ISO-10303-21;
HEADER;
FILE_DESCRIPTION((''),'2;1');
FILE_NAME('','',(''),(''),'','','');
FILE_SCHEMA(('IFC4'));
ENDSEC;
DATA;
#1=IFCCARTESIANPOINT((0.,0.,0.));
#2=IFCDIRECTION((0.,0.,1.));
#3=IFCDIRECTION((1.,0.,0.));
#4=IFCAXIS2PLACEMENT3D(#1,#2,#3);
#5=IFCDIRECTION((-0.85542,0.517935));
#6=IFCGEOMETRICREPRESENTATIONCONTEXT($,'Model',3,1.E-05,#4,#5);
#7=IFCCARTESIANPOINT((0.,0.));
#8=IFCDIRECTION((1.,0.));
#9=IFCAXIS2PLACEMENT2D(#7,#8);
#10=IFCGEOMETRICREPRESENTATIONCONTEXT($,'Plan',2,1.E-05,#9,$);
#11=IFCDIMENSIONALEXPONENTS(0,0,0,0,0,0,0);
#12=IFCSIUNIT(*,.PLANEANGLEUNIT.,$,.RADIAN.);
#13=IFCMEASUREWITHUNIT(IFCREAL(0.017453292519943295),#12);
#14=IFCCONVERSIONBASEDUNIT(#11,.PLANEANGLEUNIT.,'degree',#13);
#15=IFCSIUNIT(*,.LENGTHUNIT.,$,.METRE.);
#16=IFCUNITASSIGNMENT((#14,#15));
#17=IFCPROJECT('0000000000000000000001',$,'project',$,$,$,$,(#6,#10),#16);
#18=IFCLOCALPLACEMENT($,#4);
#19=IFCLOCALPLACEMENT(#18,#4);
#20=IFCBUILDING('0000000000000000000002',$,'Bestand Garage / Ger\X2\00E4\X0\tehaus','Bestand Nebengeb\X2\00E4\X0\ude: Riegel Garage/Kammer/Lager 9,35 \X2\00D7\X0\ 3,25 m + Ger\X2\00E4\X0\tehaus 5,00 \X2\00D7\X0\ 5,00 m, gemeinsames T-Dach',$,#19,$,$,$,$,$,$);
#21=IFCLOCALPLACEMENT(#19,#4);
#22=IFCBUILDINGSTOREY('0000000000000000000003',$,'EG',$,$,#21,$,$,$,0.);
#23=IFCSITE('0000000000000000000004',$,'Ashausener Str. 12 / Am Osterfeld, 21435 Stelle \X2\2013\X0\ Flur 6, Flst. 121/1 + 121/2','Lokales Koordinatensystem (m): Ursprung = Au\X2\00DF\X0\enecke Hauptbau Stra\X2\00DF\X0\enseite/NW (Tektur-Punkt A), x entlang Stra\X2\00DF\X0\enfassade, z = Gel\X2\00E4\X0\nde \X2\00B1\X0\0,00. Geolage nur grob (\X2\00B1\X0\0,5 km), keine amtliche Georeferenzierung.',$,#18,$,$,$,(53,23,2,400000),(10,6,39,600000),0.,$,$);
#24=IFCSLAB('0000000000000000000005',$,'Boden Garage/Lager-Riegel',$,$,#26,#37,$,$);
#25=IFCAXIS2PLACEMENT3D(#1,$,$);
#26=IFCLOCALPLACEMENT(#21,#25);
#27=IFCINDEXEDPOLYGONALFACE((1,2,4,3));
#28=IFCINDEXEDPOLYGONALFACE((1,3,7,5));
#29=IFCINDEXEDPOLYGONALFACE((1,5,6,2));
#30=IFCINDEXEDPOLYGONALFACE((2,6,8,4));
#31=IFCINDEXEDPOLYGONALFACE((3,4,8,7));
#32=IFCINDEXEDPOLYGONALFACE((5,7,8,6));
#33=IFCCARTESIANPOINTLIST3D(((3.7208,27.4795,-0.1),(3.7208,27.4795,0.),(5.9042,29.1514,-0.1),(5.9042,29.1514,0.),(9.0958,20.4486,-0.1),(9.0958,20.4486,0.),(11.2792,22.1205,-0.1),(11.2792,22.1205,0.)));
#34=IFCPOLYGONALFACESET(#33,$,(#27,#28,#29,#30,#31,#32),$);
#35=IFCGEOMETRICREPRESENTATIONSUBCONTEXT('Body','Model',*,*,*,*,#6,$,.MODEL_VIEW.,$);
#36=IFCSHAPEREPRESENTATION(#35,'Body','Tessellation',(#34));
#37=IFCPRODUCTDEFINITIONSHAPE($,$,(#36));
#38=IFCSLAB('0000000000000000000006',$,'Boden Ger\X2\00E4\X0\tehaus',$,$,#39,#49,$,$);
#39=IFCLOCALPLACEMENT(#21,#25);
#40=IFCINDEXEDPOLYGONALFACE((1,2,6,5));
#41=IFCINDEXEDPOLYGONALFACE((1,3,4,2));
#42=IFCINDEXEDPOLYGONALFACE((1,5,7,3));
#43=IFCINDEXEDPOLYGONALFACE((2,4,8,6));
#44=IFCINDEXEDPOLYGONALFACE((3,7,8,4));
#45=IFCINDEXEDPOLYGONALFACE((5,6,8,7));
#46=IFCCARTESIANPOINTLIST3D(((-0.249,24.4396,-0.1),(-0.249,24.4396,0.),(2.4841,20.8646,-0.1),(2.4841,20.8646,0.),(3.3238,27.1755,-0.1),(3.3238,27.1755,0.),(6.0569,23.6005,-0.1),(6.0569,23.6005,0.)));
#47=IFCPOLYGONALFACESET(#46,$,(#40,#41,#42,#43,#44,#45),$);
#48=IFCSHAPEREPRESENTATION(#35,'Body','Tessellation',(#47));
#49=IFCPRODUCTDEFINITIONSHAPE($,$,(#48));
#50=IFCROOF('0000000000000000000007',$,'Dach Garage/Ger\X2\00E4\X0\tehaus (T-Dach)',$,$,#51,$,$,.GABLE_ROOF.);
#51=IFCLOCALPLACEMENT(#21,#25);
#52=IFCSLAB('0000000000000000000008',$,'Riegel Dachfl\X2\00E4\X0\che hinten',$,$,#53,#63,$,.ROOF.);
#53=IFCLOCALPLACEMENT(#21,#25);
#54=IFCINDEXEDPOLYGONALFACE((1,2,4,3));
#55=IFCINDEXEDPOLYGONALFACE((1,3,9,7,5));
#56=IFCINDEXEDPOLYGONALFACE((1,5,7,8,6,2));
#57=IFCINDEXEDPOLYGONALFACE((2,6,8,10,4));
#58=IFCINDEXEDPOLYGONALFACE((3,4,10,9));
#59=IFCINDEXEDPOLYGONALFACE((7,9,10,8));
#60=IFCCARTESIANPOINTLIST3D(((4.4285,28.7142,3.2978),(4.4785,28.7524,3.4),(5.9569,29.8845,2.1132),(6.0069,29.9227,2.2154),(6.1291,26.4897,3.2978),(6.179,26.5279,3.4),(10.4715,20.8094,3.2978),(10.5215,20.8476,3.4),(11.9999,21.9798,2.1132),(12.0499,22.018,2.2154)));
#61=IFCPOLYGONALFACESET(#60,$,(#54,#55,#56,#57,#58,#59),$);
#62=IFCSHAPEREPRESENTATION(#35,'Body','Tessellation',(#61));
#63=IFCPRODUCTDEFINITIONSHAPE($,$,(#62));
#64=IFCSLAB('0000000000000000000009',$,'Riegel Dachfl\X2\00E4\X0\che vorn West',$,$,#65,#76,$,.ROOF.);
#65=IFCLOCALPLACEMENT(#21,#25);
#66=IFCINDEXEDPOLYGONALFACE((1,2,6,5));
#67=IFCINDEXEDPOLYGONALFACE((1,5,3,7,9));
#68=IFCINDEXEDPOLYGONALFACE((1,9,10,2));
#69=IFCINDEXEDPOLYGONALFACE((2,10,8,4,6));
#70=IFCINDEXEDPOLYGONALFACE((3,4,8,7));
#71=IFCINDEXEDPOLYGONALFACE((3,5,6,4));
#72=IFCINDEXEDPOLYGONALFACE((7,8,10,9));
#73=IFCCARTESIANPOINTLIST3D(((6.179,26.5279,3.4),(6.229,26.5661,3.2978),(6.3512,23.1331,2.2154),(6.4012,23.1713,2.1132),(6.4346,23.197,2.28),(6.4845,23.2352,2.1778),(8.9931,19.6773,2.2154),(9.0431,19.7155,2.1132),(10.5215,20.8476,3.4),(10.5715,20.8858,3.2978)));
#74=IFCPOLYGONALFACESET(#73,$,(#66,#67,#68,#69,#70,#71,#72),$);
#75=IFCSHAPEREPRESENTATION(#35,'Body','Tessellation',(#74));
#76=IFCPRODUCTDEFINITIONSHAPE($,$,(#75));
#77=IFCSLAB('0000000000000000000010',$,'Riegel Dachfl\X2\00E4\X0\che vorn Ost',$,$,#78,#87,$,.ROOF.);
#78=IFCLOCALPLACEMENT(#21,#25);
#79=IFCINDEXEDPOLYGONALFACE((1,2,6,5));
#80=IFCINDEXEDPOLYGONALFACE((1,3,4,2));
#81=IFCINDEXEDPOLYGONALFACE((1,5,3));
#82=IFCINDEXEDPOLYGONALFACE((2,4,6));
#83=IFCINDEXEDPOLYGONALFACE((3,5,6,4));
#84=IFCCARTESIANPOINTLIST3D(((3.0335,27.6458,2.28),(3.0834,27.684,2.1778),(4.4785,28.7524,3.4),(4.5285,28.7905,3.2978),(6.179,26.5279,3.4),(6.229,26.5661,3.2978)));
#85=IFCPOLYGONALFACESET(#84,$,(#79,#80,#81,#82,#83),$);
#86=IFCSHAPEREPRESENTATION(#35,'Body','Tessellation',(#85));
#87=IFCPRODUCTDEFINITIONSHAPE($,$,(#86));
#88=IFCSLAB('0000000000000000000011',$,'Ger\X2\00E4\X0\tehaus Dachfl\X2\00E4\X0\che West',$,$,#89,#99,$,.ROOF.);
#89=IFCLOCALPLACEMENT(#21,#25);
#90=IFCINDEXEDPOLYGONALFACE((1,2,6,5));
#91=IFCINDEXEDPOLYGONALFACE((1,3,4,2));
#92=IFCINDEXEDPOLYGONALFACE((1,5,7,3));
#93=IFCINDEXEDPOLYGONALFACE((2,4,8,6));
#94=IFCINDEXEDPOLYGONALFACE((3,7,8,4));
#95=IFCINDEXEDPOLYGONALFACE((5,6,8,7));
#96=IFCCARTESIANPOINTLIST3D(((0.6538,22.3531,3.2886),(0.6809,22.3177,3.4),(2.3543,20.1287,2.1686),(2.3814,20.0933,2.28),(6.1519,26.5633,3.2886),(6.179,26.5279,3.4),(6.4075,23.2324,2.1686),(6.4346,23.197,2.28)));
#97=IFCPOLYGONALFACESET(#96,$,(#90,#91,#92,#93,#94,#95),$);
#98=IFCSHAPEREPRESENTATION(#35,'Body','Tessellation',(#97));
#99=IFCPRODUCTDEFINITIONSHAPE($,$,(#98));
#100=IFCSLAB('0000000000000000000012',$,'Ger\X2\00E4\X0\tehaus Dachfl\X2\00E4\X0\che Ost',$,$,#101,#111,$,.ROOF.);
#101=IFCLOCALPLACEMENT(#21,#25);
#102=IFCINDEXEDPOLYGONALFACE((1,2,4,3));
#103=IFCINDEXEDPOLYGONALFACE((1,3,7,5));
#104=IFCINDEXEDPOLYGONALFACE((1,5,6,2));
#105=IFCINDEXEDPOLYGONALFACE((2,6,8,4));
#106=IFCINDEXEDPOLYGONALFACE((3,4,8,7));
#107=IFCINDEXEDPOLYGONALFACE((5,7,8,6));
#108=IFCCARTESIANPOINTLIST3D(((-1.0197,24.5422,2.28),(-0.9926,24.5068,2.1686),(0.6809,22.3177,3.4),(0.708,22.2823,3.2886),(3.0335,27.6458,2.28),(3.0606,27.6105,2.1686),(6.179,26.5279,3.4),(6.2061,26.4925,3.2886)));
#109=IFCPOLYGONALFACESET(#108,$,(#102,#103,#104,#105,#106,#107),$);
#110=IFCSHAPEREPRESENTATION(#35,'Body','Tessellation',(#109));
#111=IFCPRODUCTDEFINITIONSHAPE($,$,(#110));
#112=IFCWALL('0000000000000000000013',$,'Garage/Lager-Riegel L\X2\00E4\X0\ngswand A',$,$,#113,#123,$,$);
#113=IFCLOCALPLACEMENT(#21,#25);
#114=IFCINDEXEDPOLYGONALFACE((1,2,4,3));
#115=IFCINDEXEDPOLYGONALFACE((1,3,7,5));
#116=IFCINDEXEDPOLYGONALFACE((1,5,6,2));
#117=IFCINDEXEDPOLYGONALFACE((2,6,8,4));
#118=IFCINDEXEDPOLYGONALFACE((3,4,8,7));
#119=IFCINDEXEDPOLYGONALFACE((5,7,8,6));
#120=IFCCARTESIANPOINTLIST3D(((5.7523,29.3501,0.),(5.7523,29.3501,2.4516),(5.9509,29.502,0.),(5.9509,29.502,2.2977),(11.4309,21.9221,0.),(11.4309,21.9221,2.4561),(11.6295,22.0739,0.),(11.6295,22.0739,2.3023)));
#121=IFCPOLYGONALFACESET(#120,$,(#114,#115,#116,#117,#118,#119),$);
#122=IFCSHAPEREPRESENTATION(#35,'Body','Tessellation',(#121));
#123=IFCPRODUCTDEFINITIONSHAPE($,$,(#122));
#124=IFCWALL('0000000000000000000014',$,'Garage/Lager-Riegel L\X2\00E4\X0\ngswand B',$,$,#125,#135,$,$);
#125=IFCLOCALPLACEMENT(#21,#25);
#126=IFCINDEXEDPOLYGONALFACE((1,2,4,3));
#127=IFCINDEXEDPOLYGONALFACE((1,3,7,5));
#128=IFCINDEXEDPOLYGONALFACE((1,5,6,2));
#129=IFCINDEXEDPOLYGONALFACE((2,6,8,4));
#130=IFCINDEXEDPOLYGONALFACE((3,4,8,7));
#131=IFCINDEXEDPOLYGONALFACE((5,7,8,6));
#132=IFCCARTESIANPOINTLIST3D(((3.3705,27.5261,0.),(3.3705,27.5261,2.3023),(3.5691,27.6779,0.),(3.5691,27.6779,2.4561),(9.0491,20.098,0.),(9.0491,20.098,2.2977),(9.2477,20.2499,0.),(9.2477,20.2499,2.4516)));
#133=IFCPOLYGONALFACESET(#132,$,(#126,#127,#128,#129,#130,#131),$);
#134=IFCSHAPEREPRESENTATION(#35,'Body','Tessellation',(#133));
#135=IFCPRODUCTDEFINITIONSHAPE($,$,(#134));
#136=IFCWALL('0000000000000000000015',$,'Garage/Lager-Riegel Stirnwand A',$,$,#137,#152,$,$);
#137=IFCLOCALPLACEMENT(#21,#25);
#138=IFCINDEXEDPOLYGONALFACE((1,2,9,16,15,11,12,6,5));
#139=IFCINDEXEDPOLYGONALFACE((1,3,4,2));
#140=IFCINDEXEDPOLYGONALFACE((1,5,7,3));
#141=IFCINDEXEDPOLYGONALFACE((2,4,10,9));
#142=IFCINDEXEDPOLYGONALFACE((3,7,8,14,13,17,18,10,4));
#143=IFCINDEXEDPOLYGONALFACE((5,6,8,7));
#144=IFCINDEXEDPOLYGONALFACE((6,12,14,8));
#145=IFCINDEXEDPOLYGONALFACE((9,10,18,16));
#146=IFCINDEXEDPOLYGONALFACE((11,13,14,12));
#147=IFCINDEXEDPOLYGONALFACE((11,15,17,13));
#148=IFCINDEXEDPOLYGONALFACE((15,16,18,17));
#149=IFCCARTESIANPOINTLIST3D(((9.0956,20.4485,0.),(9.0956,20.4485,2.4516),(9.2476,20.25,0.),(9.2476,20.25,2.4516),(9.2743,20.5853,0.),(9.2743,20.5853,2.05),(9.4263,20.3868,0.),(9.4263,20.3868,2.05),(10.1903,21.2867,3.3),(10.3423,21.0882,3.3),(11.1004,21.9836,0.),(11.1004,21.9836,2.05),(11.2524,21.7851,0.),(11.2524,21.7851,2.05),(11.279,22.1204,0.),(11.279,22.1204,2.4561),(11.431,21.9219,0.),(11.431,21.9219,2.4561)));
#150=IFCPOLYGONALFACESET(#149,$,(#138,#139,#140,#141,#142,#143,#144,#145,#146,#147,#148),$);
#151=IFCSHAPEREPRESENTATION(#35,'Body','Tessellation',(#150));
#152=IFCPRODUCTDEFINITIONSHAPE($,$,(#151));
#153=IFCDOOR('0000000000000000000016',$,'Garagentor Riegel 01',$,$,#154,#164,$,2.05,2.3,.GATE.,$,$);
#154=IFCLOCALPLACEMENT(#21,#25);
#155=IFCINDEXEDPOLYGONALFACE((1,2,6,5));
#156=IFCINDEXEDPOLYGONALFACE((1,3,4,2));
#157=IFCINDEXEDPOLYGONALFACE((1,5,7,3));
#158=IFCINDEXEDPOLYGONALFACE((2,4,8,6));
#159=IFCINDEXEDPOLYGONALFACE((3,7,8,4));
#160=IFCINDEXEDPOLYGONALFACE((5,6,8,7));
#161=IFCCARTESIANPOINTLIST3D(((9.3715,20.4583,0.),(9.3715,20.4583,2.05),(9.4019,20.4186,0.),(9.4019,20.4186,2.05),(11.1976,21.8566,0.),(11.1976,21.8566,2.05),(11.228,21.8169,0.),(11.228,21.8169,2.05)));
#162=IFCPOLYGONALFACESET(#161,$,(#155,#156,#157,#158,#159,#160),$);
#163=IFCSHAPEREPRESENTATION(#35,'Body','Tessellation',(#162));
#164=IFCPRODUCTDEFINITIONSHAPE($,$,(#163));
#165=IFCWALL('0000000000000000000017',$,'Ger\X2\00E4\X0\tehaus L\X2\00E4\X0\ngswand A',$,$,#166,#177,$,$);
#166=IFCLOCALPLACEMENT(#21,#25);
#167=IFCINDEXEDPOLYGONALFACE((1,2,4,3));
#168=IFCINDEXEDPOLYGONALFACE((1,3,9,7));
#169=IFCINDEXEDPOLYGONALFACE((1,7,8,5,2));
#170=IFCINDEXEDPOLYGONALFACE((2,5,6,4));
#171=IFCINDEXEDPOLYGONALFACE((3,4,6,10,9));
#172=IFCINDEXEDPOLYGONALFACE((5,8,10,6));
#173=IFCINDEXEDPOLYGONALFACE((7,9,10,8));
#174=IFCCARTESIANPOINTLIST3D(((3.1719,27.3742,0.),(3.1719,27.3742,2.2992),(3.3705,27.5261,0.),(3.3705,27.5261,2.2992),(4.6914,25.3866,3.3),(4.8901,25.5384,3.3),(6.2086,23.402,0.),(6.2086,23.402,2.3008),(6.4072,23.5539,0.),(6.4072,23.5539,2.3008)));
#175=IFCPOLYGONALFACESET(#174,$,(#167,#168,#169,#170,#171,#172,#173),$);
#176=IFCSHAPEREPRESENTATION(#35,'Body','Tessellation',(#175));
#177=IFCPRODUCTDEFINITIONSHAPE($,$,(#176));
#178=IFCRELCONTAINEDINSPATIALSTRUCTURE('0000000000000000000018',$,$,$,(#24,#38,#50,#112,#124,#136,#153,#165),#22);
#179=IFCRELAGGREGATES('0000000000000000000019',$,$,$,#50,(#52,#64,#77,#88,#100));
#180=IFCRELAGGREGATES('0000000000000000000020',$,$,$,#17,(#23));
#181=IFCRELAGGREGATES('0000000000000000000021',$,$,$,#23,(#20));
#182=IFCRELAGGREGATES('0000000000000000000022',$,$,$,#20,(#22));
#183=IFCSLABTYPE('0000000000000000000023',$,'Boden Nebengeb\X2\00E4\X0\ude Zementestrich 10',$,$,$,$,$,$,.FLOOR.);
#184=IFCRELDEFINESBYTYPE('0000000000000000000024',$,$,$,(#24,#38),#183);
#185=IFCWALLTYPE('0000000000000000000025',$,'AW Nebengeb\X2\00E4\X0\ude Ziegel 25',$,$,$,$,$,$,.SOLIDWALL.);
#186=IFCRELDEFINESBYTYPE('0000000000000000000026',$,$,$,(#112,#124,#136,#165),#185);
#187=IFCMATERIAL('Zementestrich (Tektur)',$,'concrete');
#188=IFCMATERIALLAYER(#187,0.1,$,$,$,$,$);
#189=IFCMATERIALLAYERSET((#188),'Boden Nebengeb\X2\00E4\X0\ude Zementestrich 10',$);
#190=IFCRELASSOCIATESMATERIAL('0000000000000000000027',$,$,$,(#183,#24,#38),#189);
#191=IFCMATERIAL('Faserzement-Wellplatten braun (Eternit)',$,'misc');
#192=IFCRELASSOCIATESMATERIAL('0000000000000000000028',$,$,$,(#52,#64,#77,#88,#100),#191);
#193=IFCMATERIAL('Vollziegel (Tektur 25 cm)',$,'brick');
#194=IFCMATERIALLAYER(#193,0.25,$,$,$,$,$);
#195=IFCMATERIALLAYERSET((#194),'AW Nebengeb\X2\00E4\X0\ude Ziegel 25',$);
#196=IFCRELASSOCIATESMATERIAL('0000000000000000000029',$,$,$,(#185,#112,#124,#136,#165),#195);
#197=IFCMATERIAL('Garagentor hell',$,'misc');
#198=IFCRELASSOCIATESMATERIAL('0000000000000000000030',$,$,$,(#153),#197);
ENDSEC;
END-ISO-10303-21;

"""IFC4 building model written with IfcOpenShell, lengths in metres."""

from ifc_helpers import new_model, entity, si_unit, converted_unit, direction, frame, origin_with_axes, origin_2d_with_axis, place, context, subcontext, project, spatial, polyline, indexed_curve, outline, extrude, clip, halfspace, material, layer, layer_set, layer_usage, type_object, element, fill, aggregate, save


model = new_model("IFC4")

# Units and contexts
model_context = context("Model", 3, precision=1e-05, world=origin_with_axes(), true_north=direction((-0.85542, 0.517935)))
plan_context = context("Plan", 2, precision=1e-05, world=origin_2d_with_axis())
body_context = subcontext(model_context, "Body", "Model", "MODEL_VIEW")
ifc_project = project(units=[converted_unit("PLANEANGLEUNIT", "degree", entity("IfcReal", 0.017453292519943295), si_unit("PLANEANGLEUNIT", "RADIAN"), dimensions=[0, 0, 0, 0, 0, 0, 0]), si_unit("LENGTHUNIT", "METRE")], contexts=[model_context, plan_context])

# Site, building, storey
site_placement = place(None, origin_with_axes())
site = spatial("IfcSite", under=ifc_project, at=site_placement, Name="Ashausener Str. 12 / Am Osterfeld, 21435 Stelle – Flur 6, Flst. 121/1 + 121/2", Description="Lokales Koordinatensystem (m): Ursprung = Außenecke Hauptbau Straßenseite/NW (Tektur-Punkt A), x entlang Straßenfassade, z = Gelände ±0,00. Geolage nur grob (±0,5 km), keine amtliche Georeferenzierung.", RefLatitude=(53, 23, 2, 400000), RefLongitude=(10, 6, 39, 600000), RefElevation=0.0)
building_placement = place(site_placement, origin_with_axes())
building = spatial("IfcBuilding", under=site, at=building_placement, Name="Bestand Garage / Gerätehaus", Description="Bestand Nebengebäude: Riegel Garage/Kammer/Lager 9,35 × 3,25 m + Gerätehaus 5,00 × 5,00 m, gemeinsames T-Dach")
storey_placement = place(building_placement, origin_with_axes())
storey = spatial("IfcBuildingStorey", under=building, at=storey_placement, Name="EG", Elevation=0.0)

# Slabs
ifc_material_1 = material(Name="Zementestrich (Tektur)", Category="concrete")
ifc_layer_1 = layer(ifc_material_1, 0.1)
ifc_layer_set_1 = layer_set([ifc_layer_1], Name="Boden Nebengebäude Zementestrich 10")
ifc_layer_usage_1 = layer_usage(ifc_layer_set_1, "AXIS3", "POSITIVE", 0.0)
slab_type = type_object("IfcSlabType", Name="Boden Nebengebäude Zementestrich 10", PredefinedType="FLOOR", material=ifc_layer_set_1)
slab_1_placement = place(storey_placement, origin_with_axes())
element("IfcSlab", 1, at=slab_1_placement, inside=storey, type_object=slab_type, material=ifc_layer_usage_1, Name="Boden Garage/Lager-Riegel", context=body_context, shape_type="SweptSolid", body=[
    extrude(outline(polyline([(11.2792, 22.1205), (5.9042, 29.1514), (3.7208, 27.4795), (9.0958, 20.4486), (11.2792, 22.1205)])), frame((0.0, 0.0, -0.1)), (0.0, 0.0, 1.0), 0.1),
])
ifc_layer_usage_2 = layer_usage(ifc_layer_set_1, "AXIS3", "POSITIVE", 0.0)
slab_2_placement = place(storey_placement, origin_with_axes())
element("IfcSlab", 2, at=slab_2_placement, inside=storey, type_object=slab_type, material=ifc_layer_usage_2, Name="Boden Gerätehaus", context=body_context, shape_type="SweptSolid", body=[
    extrude(outline(polyline([(6.0569, 23.6005), (3.3238, 27.1755), (-0.249, 24.4396), (2.4841, 20.8646), (6.0569, 23.6005)])), frame((0.0, 0.0, -0.1)), (0.0, 0.0, 1.0), 0.1),
])

# Roof, slabs
roof_placement = place(storey_placement, origin_with_axes())
roof = element("IfcRoof", 3, at=roof_placement, inside=storey, Name="Dach Garage/Gerätehaus (T-Dach)", PredefinedType="GABLE_ROOF")
ifc_material_2 = material(Name="Faserzement-Wellplatten braun (Eternit)", Category="misc")
slab_3_placement = place(roof_placement, origin_with_axes())
slab_3 = element("IfcSlab", 4, at=slab_3_placement, material=ifc_material_2, Name="Riegel Dachfläche hinten", PredefinedType="ROOF", context=body_context, shape_type="SweptSolid", body=[
    extrude(outline(polyline([(0.0, 0.0), (9.95, 0.0), (9.9485, 2.2603), (7.1485, 2.2603), (-0.0015, 2.2603), (0.0, 0.0)])), frame((12.0499, 22.018, 2.2154), z_axis=(0.416367, 0.318306, 0.851657), x_axis=(-0.607339, 0.794443, 0.0)), (0.0, 0.0, -1.0), 0.12),
])
slab_4_placement = place(roof_placement, origin_with_axes())
slab_4 = element("IfcSlab", 5, at=slab_4_placement, material=ifc_material_2, Name="Riegel Dachfläche vorn West", PredefinedType="ROOF", context=body_context, shape_type="SweptSolid", body=[
    extrude(outline(polyline([(0.0, 0.0), (7.15, 0.0), (4.3486, 2.137), (4.3485, 2.2603), (-0.0015, 2.2603), (0.0, 0.0)])), frame((10.5215, 20.8476, 3.4), z_axis=(-0.416366, -0.318306, 0.851658), x_axis=(-0.607339, 0.794443, 0.0)), (0.0, 0.0, -1.0), 0.12),
])
slab_5_placement = place(roof_placement, origin_with_axes())
slab_5 = element("IfcSlab", 6, at=slab_5_placement, material=ifc_material_2, Name="Riegel Dachfläche vorn Ost", PredefinedType="ROOF", context=body_context, shape_type="SweptSolid", body=[
    extrude(outline(polyline([(0.0, 0.0), (2.8, 0.0), (2.7986, 2.137), (0.0, 0.0)])), frame((6.179, 26.5279, 3.4), z_axis=(-0.416366, -0.318305, 0.851658), x_axis=(-0.607339, 0.794443, 0.0)), (0.0, 0.0, -1.0), 0.12),
])
slab_6_placement = place(roof_placement, origin_with_axes())
slab_6 = element("IfcSlab", 7, at=slab_6_placement, material=ifc_material_2, Name="Gerätehaus Dachfläche West", PredefinedType="ROOF", context=body_context, shape_type="SweptSolid", body=[
    extrude(outline(polyline([(0.0, 0.0), (6.925, 0.0), (6.9272, 3.0157), (1.8222, 3.0157), (0.0, 0.0)])), frame((6.179, 26.5279, 3.4), z_axis=(0.225794, -0.294869, 0.928477), x_axis=(-0.79396, -0.60797, 0.0)), (0.0, 0.0, -1.0), 0.12),
])
slab_7_placement = place(roof_placement, origin_with_axes())
slab_7 = element("IfcSlab", 8, at=slab_7_placement, material=ifc_material_2, Name="Gerätehaus Dachfläche Ost", PredefinedType="ROOF", context=body_context, shape_type="SweptSolid", body=[
    extrude(outline(polyline([(0.0, 0.0), (3.5212, 0.0), (6.1566, 4.3721), (3.575, 5.9309), (0.0, 0.0)])), frame((6.179, 26.5279, 3.4), z_axis=(-0.225794, 0.294869, 0.928477), x_axis=(-0.893325, 0.317489, -0.318075)), (0.0, 0.0, -1.0), 0.12),
])
aggregate(roof, [slab_3, slab_4, slab_5, slab_6, slab_7])

# Walls
ifc_material_3 = material(Name="Vollziegel (Tektur 25 cm)", Category="brick")
ifc_layer_2 = layer(ifc_material_3, 0.25)
ifc_layer_set_2 = layer_set([ifc_layer_2], Name="AW Nebengebäude Ziegel 25")
ifc_layer_usage_3 = layer_usage(ifc_layer_set_2, "AXIS2", "POSITIVE", 0.0)
wall_type = type_object("IfcWallType", Name="AW Nebengebäude Ziegel 25", PredefinedType="SOLIDWALL", material=ifc_layer_set_2)
wall_1_placement = place(storey_placement, frame((11.6295, 22.0739, 0.0), z_axis=(0.0, 0.0, 1.0), x_axis=(-0.607339, 0.794443, 0.0)))
element("IfcWall", 9, at=wall_1_placement, inside=storey, type_object=wall_type, material=ifc_layer_usage_3, Name="Garage/Lager-Riegel Längswand A", context=body_context, shape_type="Clipping", body=[
    clip(clip(extrude(outline(indexed_curve([(0.0, 0.0), (0.0, 0.25), (9.35, 0.25), (9.35, 0.0), (0.0, 0.0)], self_intersect=False)), origin_with_axes(), (0.0, 0.0, 1.0), 6.0), halfspace(frame((4.6724, 3.25, 2.3), z_axis=(-0.000416, 0.5241, 0.85166), x_axis=(1.0, 0.000795, 0.0)), False)), halfspace(frame((4.675, 0.0, 2.3), z_axis=(0.000416, -0.5241, 0.85166), x_axis=(-1.0, -0.000795, 0.0)), False)),
])
ifc_layer_usage_4 = layer_usage(ifc_layer_set_2, "AXIS2", "POSITIVE", 0.0)
wall_2_placement = place(storey_placement, frame((3.3705, 27.5261, 0.0), z_axis=(0.0, 0.0, 1.0), x_axis=(0.607339, -0.794443, 0.0)))
element("IfcWall", 10, at=wall_2_placement, inside=storey, type_object=wall_type, material=ifc_layer_usage_4, Name="Garage/Lager-Riegel Längswand B", context=body_context, shape_type="Clipping", body=[
    clip(clip(extrude(outline(indexed_curve([(0.0, 0.0), (0.0, 0.25), (9.35, 0.25), (9.35, 0.0), (0.0, 0.0)], self_intersect=False)), origin_with_axes(), (0.0, 0.0, 1.0), 6.0), halfspace(frame((4.675, 0.0, 2.3), z_axis=(0.000416, -0.5241, 0.85166), x_axis=(-1.0, -0.000795, 0.0)), False)), halfspace(frame((4.6724, 3.25, 2.3), z_axis=(-0.000416, 0.5241, 0.85166), x_axis=(1.0, 0.000795, 0.0)), False)),
])

# Wall, opening, door
ifc_layer_usage_5 = layer_usage(ifc_layer_set_2, "AXIS2", "POSITIVE", 0.0)
wall_3_placement = place(storey_placement, frame((9.2476, 20.25, 0.0), z_axis=(0.0, 0.0, 1.0), x_axis=(0.79396, 0.60797, 0.0)))
wall_3 = element("IfcWall", 11, at=wall_3_placement, inside=storey, type_object=wall_type, material=ifc_layer_usage_5, Name="Garage/Lager-Riegel Stirnwand A", context=body_context, shape_type="Clipping", body=[
    clip(clip(extrude(outline(indexed_curve([(0.0, 0.0), (0.0, 0.25), (2.75, 0.25), (2.75, 0.0), (0.0, 0.0)], self_intersect=False)), origin_with_axes(), (0.0, 0.0, 1.0), 6.0), halfspace(frame((-0.2463, 4.675, 2.3), z_axis=(-0.5241, 0.0, 0.85166), x_axis=(0.0, 1.0, 0.0)), False)), halfspace(frame((3.0037, 4.675, 2.3), z_axis=(0.5241, 0.0, 0.85166), x_axis=(0.0, -1.0, 0.0)), False)),
])
opening_1_placement = place(wall_3_placement, frame((0.225, -0.1, 0.0), z_axis=(0.0, 0.0, 1.0), x_axis=(1.0, 0.0, 0.0)))
opening_1 = element("IfcOpeningElement", 12, at=opening_1_placement, cuts=wall_3, context=body_context, shape_type="SweptSolid", body=[
    extrude(outline(indexed_curve([(0.0, 0.0), (0.0, 0.45), (2.3, 0.45), (2.3, 0.0), (0.0, 0.0)], self_intersect=False)), origin_with_axes(), (0.0, 0.0, 1.0), 2.05),
])
ifc_material_4 = material(Name="Garagentor hell", Category="misc")
door_1_placement = place(storey_placement, frame((9.4019, 20.4186, 0.0), z_axis=(0.0, 0.0, 1.0), x_axis=(0.79396, 0.60797, 0.0)))
door_1 = element("IfcDoor", 13, at=door_1_placement, inside=storey, material=ifc_material_4, Name="Garagentor Riegel 01", OverallHeight=2.05, OverallWidth=2.3, PredefinedType="GATE", context=body_context, shape_type="SweptSolid", body=[
    extrude(outline(indexed_curve([(0.0, 0.0), (0.0, 0.05), (2.3, 0.05), (2.3, 0.0), (0.0, 0.0)], self_intersect=False)), origin_with_axes(), (0.0, 0.0, 1.0), 2.05),
])
fill(opening_1, door_1)

# Wall
ifc_layer_usage_6 = layer_usage(ifc_layer_set_2, "AXIS2", "POSITIVE", 0.0)
wall_4_placement = place(storey_placement, frame((6.4072, 23.5539, 0.0), z_axis=(0.0, 0.0, 1.0), x_axis=(-0.607339, 0.794443, 0.0)))
element("IfcWall", 14, at=wall_4_placement, inside=storey, type_object=wall_type, material=ifc_layer_usage_6, Name="Gerätehaus Längswand A", context=body_context, shape_type="Clipping", body=[
    clip(clip(extrude(outline(indexed_curve([(0.0, 0.0), (0.0, 0.25), (5.0, 0.25), (5.0, 0.0), (0.0, 0.0)], self_intersect=False)), origin_with_axes(), (0.0, 0.0, 1.0), 6.0), halfspace(frame((4.998, 2.5, 2.3), z_axis=(0.37139, 0.0, 0.92848), x_axis=(0.0, -1.0, 0.0)), False)), halfspace(frame((-0.002, 2.5, 2.3), z_axis=(-0.37139, 0.0, 0.92848), x_axis=(0.0, 1.0, 0.0)), False)),
])

save(model, "model.ifc")
